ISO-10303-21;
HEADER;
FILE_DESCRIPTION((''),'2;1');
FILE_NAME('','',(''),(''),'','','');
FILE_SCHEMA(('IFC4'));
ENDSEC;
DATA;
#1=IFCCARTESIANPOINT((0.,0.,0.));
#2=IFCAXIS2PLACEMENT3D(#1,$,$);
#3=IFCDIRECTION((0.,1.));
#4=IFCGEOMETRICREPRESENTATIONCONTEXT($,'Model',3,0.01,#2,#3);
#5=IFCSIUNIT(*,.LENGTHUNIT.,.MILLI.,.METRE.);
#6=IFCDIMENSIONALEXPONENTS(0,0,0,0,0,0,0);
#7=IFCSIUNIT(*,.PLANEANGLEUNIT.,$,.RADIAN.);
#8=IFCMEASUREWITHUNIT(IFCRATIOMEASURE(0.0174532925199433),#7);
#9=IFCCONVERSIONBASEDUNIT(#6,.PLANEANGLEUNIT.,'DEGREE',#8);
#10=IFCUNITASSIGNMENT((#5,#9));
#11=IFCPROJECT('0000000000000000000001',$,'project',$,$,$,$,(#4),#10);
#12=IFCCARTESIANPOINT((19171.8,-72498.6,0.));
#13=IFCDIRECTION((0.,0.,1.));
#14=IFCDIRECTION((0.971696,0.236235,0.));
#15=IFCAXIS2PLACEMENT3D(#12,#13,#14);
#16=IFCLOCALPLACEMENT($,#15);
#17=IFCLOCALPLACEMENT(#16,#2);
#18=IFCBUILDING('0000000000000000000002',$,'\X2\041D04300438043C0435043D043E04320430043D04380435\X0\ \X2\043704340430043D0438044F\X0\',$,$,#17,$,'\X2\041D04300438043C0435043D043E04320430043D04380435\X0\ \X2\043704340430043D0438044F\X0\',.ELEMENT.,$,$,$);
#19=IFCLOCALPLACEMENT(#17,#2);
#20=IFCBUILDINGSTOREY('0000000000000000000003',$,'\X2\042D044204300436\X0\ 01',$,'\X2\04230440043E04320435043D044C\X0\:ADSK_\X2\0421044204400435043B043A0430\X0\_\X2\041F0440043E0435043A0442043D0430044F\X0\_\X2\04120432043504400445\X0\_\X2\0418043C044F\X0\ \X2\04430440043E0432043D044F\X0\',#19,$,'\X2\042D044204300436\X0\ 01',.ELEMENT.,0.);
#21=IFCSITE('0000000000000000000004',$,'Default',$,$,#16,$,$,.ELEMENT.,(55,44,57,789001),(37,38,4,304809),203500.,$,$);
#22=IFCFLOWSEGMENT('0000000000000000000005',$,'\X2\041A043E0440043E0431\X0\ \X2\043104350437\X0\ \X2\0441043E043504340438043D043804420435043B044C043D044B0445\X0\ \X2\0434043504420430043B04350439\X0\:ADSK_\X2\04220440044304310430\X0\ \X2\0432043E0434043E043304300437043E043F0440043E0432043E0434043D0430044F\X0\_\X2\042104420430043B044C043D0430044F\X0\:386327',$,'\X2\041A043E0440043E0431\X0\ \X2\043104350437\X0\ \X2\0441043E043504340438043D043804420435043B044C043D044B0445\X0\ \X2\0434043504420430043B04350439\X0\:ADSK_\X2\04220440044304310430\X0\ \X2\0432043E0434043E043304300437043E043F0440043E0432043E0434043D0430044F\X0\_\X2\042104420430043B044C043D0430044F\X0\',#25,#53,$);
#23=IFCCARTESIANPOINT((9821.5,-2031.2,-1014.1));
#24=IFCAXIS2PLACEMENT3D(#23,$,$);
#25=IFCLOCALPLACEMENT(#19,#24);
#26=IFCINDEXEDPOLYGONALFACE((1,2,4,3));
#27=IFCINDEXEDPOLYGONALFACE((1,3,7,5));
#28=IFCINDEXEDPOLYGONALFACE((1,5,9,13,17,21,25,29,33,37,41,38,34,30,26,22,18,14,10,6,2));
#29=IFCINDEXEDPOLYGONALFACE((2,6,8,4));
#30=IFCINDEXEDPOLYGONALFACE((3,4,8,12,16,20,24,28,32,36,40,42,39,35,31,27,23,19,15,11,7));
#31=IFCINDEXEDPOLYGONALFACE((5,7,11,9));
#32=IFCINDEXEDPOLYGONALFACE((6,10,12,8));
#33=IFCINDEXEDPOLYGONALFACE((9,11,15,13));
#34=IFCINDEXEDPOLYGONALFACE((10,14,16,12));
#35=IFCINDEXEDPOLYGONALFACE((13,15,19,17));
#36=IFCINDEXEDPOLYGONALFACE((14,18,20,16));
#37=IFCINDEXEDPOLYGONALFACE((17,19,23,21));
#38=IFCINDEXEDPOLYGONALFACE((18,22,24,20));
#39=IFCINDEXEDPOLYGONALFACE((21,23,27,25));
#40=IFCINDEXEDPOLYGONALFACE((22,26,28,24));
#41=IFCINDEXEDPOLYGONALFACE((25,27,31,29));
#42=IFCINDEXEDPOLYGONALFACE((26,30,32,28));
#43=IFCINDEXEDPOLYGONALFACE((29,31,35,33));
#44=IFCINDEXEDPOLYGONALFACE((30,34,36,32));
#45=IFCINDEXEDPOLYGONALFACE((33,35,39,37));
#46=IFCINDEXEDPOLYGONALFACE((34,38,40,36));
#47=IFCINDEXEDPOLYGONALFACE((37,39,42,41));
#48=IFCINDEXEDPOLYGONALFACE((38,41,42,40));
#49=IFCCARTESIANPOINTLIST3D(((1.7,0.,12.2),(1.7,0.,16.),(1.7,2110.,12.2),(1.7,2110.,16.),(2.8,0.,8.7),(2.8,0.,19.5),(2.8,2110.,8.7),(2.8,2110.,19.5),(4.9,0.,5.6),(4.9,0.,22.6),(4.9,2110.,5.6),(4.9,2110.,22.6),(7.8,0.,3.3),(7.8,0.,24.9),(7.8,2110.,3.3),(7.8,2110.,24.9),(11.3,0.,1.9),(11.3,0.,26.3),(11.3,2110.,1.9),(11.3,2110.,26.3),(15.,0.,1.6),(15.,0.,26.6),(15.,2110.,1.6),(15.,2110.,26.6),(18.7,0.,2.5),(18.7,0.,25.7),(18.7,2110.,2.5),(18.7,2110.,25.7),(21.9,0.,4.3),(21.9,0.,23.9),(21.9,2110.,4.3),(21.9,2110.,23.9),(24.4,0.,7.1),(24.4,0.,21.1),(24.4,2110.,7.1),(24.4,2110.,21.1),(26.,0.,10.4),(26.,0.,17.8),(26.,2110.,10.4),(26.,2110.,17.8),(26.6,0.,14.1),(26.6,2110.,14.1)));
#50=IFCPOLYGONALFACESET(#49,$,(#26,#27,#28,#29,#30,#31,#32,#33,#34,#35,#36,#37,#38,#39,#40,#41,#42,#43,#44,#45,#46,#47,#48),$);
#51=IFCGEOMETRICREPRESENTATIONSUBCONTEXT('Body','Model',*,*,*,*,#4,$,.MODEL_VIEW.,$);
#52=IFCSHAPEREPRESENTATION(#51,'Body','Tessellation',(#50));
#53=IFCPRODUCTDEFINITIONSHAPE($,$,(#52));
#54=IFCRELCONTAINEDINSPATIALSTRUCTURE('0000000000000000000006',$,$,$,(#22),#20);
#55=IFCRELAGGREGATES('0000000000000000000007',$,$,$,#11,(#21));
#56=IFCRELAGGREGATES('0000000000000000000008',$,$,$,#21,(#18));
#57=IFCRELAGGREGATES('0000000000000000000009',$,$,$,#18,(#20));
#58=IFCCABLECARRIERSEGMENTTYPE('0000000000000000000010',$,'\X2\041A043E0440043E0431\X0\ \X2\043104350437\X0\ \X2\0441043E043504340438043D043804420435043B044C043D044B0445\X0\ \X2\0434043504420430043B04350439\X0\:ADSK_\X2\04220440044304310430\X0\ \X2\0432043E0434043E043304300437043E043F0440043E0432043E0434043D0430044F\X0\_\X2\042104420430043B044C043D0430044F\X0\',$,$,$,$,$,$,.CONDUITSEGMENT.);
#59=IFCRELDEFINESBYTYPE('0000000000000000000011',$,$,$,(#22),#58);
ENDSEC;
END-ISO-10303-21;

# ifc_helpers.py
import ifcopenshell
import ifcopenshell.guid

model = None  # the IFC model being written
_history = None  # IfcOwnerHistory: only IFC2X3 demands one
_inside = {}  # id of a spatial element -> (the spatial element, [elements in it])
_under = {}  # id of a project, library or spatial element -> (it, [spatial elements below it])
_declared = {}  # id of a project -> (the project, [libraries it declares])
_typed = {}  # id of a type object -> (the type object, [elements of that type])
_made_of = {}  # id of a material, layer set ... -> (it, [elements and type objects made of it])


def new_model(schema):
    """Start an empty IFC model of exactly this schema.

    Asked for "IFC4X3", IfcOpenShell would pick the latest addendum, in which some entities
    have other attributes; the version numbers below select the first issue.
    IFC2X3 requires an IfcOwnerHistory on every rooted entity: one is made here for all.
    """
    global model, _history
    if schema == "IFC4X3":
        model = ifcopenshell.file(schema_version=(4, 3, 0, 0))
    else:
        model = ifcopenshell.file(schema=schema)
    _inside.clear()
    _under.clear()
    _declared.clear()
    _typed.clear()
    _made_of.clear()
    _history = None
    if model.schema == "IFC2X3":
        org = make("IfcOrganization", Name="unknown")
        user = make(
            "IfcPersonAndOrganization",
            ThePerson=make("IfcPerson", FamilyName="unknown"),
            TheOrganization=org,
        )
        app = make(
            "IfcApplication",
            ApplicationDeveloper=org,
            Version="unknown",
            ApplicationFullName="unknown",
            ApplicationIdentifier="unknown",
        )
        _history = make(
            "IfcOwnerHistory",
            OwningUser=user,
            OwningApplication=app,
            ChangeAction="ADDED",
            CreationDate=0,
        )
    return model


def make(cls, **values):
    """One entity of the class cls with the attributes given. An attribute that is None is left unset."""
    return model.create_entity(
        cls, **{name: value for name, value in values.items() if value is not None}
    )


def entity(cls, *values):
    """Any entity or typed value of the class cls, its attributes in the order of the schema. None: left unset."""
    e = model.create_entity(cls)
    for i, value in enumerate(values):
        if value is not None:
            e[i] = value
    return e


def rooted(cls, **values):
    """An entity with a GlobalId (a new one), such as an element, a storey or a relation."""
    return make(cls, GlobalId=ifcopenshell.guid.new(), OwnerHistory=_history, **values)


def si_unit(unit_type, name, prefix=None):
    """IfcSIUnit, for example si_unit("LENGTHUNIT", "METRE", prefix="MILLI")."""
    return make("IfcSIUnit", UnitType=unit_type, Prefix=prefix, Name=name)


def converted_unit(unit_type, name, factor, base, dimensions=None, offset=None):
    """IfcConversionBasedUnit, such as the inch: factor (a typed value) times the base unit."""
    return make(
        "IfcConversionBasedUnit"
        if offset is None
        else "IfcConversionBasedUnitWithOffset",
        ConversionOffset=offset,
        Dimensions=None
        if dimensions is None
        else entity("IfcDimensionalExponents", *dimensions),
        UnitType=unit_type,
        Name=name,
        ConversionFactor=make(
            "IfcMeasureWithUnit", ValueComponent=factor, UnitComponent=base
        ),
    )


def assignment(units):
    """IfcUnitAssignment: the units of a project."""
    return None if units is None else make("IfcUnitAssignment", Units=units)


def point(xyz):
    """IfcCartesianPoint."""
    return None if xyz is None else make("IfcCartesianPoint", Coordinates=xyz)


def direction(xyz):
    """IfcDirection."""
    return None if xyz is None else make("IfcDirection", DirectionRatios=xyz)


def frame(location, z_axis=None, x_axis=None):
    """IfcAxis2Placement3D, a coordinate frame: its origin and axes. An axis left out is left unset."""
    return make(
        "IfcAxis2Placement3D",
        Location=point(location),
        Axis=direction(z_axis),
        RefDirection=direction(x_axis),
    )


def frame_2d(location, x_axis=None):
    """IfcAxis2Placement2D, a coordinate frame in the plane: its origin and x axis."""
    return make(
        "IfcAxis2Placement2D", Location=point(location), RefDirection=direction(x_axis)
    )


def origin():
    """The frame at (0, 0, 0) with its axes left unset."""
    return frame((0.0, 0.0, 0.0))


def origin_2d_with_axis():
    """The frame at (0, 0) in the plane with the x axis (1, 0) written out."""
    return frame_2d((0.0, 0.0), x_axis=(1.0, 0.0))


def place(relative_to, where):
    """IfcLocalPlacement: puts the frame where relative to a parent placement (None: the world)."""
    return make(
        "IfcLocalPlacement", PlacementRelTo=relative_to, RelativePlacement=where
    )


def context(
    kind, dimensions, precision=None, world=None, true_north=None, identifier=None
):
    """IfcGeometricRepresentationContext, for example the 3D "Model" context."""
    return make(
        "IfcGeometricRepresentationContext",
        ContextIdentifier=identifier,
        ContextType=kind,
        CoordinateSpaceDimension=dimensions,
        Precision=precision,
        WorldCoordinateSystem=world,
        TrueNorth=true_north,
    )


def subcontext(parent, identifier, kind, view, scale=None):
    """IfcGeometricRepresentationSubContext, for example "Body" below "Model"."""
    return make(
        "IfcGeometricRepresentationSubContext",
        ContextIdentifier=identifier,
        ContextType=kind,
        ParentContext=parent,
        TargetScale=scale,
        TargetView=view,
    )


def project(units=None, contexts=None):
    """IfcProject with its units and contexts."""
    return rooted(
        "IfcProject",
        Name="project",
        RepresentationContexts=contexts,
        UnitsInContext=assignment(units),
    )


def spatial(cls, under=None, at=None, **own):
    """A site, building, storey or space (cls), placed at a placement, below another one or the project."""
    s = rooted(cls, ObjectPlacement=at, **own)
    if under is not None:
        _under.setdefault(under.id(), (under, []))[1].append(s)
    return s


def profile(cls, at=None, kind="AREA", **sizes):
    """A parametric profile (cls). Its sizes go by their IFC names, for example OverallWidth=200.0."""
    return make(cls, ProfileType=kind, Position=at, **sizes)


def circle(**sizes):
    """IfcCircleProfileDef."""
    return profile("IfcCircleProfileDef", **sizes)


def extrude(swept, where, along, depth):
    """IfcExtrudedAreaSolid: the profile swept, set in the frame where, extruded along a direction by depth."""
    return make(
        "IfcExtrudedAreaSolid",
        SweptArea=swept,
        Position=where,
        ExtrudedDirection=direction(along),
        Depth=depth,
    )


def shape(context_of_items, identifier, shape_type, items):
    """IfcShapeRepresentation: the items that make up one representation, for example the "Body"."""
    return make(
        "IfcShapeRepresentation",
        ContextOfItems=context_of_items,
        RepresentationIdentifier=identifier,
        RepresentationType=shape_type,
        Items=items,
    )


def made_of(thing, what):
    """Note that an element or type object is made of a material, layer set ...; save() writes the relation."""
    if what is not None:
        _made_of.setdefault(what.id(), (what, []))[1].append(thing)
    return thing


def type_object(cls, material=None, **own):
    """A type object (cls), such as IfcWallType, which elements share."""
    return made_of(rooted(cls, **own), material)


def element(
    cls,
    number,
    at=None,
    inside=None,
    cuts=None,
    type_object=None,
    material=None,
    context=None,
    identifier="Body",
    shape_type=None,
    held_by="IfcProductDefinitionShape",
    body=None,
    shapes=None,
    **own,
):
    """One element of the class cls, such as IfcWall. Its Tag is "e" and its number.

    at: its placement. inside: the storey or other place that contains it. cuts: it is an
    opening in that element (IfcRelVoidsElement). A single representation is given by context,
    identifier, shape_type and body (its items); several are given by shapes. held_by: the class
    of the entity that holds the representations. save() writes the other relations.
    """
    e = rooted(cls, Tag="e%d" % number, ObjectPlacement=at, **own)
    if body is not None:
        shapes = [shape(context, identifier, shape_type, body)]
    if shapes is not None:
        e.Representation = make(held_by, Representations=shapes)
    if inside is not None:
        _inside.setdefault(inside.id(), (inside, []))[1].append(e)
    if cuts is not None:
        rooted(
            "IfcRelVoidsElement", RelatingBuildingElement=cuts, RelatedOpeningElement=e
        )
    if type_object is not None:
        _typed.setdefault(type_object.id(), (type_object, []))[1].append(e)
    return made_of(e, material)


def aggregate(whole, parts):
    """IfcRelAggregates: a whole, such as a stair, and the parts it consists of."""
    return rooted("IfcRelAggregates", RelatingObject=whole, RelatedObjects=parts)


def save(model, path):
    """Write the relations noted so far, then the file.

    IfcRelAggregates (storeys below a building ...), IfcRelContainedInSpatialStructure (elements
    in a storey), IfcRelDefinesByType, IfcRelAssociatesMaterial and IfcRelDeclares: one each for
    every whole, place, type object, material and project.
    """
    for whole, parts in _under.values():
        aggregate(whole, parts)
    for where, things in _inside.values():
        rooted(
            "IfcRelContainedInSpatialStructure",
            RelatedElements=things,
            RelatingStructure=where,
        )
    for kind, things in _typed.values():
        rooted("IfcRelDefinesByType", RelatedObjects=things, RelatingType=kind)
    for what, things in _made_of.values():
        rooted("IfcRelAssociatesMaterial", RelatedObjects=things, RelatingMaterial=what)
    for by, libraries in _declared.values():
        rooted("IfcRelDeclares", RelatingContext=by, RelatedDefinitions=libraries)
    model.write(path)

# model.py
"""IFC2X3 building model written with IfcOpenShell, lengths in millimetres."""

from ifc_helpers import new_model, entity, si_unit, converted_unit, direction, frame, origin, origin_2d_with_axis, place, context, subcontext, project, spatial, circle, extrude, type_object, element, save


model = new_model("IFC2X3")

# Units and contexts
model_context = context("Model", 3, precision=0.01, world=origin(), true_north=direction((0.0, 1.0)))
body_context = subcontext(model_context, "Body", "Model", "MODEL_VIEW")
ifc_project = project(units=[si_unit("LENGTHUNIT", "METRE", prefix="MILLI"), converted_unit("PLANEANGLEUNIT", "DEGREE", entity("IfcRatioMeasure", 0.0174532925199433), si_unit("PLANEANGLEUNIT", "RADIAN"), dimensions=[0, 0, 0, 0, 0, 0, 0])], contexts=[model_context])

# Site, building, storey
site_placement = place(None, frame((19171.8, -72498.6, 0.0), z_axis=(0.0, 0.0, 1.0), x_axis=(0.971696, 0.236235, 0.0)))
site = spatial("IfcSite", under=ifc_project, at=site_placement, Name="Default", CompositionType="ELEMENT", RefLatitude=(55, 44, 57, 789001), RefLongitude=(37, 38, 4, 304809), RefElevation=203500.0)
building_placement = place(site_placement, origin())
building = spatial("IfcBuilding", under=site, at=building_placement, Name="Наименование здания", LongName="Наименование здания", CompositionType="ELEMENT")
storey_placement = place(building_placement, origin())
storey = spatial("IfcBuildingStorey", under=building, at=storey_placement, Name="Этаж 01", ObjectType="Уровень:ADSK_Стрелка_Проектная_Вверх_Имя уровня", LongName="Этаж 01", CompositionType="ELEMENT", Elevation=0.0)

# Flow segment
cable_carrier_segment_type_1 = type_object("IfcCableCarrierSegmentType", Name="Короб без соединительных деталей:ADSK_Труба водогазопроводная_Стальная", PredefinedType="CONDUITSEGMENT")
flow_segment_1_placement = place(storey_placement, frame((9821.5, -2031.2, -1014.1)))
element("IfcFlowSegment", 1, at=flow_segment_1_placement, inside=storey, type_object=cable_carrier_segment_type_1, Name="Короб без соединительных деталей:ADSK_Труба водогазопроводная_Стальная:386327", ObjectType="Короб без соединительных деталей:ADSK_Труба водогазопроводная_Стальная", context=body_context, shape_type="SweptSolid", body=[
    extrude(circle(Radius=12.5, at=origin_2d_with_axis()), frame((14.1, 0.0, 14.1), z_axis=(0.0, 1.0, 0.0), x_axis=(1.0, 0.0, 0.0)), (0.0, 0.0, 1.0), 2110.0),
])

save(model, "model.ifc")
